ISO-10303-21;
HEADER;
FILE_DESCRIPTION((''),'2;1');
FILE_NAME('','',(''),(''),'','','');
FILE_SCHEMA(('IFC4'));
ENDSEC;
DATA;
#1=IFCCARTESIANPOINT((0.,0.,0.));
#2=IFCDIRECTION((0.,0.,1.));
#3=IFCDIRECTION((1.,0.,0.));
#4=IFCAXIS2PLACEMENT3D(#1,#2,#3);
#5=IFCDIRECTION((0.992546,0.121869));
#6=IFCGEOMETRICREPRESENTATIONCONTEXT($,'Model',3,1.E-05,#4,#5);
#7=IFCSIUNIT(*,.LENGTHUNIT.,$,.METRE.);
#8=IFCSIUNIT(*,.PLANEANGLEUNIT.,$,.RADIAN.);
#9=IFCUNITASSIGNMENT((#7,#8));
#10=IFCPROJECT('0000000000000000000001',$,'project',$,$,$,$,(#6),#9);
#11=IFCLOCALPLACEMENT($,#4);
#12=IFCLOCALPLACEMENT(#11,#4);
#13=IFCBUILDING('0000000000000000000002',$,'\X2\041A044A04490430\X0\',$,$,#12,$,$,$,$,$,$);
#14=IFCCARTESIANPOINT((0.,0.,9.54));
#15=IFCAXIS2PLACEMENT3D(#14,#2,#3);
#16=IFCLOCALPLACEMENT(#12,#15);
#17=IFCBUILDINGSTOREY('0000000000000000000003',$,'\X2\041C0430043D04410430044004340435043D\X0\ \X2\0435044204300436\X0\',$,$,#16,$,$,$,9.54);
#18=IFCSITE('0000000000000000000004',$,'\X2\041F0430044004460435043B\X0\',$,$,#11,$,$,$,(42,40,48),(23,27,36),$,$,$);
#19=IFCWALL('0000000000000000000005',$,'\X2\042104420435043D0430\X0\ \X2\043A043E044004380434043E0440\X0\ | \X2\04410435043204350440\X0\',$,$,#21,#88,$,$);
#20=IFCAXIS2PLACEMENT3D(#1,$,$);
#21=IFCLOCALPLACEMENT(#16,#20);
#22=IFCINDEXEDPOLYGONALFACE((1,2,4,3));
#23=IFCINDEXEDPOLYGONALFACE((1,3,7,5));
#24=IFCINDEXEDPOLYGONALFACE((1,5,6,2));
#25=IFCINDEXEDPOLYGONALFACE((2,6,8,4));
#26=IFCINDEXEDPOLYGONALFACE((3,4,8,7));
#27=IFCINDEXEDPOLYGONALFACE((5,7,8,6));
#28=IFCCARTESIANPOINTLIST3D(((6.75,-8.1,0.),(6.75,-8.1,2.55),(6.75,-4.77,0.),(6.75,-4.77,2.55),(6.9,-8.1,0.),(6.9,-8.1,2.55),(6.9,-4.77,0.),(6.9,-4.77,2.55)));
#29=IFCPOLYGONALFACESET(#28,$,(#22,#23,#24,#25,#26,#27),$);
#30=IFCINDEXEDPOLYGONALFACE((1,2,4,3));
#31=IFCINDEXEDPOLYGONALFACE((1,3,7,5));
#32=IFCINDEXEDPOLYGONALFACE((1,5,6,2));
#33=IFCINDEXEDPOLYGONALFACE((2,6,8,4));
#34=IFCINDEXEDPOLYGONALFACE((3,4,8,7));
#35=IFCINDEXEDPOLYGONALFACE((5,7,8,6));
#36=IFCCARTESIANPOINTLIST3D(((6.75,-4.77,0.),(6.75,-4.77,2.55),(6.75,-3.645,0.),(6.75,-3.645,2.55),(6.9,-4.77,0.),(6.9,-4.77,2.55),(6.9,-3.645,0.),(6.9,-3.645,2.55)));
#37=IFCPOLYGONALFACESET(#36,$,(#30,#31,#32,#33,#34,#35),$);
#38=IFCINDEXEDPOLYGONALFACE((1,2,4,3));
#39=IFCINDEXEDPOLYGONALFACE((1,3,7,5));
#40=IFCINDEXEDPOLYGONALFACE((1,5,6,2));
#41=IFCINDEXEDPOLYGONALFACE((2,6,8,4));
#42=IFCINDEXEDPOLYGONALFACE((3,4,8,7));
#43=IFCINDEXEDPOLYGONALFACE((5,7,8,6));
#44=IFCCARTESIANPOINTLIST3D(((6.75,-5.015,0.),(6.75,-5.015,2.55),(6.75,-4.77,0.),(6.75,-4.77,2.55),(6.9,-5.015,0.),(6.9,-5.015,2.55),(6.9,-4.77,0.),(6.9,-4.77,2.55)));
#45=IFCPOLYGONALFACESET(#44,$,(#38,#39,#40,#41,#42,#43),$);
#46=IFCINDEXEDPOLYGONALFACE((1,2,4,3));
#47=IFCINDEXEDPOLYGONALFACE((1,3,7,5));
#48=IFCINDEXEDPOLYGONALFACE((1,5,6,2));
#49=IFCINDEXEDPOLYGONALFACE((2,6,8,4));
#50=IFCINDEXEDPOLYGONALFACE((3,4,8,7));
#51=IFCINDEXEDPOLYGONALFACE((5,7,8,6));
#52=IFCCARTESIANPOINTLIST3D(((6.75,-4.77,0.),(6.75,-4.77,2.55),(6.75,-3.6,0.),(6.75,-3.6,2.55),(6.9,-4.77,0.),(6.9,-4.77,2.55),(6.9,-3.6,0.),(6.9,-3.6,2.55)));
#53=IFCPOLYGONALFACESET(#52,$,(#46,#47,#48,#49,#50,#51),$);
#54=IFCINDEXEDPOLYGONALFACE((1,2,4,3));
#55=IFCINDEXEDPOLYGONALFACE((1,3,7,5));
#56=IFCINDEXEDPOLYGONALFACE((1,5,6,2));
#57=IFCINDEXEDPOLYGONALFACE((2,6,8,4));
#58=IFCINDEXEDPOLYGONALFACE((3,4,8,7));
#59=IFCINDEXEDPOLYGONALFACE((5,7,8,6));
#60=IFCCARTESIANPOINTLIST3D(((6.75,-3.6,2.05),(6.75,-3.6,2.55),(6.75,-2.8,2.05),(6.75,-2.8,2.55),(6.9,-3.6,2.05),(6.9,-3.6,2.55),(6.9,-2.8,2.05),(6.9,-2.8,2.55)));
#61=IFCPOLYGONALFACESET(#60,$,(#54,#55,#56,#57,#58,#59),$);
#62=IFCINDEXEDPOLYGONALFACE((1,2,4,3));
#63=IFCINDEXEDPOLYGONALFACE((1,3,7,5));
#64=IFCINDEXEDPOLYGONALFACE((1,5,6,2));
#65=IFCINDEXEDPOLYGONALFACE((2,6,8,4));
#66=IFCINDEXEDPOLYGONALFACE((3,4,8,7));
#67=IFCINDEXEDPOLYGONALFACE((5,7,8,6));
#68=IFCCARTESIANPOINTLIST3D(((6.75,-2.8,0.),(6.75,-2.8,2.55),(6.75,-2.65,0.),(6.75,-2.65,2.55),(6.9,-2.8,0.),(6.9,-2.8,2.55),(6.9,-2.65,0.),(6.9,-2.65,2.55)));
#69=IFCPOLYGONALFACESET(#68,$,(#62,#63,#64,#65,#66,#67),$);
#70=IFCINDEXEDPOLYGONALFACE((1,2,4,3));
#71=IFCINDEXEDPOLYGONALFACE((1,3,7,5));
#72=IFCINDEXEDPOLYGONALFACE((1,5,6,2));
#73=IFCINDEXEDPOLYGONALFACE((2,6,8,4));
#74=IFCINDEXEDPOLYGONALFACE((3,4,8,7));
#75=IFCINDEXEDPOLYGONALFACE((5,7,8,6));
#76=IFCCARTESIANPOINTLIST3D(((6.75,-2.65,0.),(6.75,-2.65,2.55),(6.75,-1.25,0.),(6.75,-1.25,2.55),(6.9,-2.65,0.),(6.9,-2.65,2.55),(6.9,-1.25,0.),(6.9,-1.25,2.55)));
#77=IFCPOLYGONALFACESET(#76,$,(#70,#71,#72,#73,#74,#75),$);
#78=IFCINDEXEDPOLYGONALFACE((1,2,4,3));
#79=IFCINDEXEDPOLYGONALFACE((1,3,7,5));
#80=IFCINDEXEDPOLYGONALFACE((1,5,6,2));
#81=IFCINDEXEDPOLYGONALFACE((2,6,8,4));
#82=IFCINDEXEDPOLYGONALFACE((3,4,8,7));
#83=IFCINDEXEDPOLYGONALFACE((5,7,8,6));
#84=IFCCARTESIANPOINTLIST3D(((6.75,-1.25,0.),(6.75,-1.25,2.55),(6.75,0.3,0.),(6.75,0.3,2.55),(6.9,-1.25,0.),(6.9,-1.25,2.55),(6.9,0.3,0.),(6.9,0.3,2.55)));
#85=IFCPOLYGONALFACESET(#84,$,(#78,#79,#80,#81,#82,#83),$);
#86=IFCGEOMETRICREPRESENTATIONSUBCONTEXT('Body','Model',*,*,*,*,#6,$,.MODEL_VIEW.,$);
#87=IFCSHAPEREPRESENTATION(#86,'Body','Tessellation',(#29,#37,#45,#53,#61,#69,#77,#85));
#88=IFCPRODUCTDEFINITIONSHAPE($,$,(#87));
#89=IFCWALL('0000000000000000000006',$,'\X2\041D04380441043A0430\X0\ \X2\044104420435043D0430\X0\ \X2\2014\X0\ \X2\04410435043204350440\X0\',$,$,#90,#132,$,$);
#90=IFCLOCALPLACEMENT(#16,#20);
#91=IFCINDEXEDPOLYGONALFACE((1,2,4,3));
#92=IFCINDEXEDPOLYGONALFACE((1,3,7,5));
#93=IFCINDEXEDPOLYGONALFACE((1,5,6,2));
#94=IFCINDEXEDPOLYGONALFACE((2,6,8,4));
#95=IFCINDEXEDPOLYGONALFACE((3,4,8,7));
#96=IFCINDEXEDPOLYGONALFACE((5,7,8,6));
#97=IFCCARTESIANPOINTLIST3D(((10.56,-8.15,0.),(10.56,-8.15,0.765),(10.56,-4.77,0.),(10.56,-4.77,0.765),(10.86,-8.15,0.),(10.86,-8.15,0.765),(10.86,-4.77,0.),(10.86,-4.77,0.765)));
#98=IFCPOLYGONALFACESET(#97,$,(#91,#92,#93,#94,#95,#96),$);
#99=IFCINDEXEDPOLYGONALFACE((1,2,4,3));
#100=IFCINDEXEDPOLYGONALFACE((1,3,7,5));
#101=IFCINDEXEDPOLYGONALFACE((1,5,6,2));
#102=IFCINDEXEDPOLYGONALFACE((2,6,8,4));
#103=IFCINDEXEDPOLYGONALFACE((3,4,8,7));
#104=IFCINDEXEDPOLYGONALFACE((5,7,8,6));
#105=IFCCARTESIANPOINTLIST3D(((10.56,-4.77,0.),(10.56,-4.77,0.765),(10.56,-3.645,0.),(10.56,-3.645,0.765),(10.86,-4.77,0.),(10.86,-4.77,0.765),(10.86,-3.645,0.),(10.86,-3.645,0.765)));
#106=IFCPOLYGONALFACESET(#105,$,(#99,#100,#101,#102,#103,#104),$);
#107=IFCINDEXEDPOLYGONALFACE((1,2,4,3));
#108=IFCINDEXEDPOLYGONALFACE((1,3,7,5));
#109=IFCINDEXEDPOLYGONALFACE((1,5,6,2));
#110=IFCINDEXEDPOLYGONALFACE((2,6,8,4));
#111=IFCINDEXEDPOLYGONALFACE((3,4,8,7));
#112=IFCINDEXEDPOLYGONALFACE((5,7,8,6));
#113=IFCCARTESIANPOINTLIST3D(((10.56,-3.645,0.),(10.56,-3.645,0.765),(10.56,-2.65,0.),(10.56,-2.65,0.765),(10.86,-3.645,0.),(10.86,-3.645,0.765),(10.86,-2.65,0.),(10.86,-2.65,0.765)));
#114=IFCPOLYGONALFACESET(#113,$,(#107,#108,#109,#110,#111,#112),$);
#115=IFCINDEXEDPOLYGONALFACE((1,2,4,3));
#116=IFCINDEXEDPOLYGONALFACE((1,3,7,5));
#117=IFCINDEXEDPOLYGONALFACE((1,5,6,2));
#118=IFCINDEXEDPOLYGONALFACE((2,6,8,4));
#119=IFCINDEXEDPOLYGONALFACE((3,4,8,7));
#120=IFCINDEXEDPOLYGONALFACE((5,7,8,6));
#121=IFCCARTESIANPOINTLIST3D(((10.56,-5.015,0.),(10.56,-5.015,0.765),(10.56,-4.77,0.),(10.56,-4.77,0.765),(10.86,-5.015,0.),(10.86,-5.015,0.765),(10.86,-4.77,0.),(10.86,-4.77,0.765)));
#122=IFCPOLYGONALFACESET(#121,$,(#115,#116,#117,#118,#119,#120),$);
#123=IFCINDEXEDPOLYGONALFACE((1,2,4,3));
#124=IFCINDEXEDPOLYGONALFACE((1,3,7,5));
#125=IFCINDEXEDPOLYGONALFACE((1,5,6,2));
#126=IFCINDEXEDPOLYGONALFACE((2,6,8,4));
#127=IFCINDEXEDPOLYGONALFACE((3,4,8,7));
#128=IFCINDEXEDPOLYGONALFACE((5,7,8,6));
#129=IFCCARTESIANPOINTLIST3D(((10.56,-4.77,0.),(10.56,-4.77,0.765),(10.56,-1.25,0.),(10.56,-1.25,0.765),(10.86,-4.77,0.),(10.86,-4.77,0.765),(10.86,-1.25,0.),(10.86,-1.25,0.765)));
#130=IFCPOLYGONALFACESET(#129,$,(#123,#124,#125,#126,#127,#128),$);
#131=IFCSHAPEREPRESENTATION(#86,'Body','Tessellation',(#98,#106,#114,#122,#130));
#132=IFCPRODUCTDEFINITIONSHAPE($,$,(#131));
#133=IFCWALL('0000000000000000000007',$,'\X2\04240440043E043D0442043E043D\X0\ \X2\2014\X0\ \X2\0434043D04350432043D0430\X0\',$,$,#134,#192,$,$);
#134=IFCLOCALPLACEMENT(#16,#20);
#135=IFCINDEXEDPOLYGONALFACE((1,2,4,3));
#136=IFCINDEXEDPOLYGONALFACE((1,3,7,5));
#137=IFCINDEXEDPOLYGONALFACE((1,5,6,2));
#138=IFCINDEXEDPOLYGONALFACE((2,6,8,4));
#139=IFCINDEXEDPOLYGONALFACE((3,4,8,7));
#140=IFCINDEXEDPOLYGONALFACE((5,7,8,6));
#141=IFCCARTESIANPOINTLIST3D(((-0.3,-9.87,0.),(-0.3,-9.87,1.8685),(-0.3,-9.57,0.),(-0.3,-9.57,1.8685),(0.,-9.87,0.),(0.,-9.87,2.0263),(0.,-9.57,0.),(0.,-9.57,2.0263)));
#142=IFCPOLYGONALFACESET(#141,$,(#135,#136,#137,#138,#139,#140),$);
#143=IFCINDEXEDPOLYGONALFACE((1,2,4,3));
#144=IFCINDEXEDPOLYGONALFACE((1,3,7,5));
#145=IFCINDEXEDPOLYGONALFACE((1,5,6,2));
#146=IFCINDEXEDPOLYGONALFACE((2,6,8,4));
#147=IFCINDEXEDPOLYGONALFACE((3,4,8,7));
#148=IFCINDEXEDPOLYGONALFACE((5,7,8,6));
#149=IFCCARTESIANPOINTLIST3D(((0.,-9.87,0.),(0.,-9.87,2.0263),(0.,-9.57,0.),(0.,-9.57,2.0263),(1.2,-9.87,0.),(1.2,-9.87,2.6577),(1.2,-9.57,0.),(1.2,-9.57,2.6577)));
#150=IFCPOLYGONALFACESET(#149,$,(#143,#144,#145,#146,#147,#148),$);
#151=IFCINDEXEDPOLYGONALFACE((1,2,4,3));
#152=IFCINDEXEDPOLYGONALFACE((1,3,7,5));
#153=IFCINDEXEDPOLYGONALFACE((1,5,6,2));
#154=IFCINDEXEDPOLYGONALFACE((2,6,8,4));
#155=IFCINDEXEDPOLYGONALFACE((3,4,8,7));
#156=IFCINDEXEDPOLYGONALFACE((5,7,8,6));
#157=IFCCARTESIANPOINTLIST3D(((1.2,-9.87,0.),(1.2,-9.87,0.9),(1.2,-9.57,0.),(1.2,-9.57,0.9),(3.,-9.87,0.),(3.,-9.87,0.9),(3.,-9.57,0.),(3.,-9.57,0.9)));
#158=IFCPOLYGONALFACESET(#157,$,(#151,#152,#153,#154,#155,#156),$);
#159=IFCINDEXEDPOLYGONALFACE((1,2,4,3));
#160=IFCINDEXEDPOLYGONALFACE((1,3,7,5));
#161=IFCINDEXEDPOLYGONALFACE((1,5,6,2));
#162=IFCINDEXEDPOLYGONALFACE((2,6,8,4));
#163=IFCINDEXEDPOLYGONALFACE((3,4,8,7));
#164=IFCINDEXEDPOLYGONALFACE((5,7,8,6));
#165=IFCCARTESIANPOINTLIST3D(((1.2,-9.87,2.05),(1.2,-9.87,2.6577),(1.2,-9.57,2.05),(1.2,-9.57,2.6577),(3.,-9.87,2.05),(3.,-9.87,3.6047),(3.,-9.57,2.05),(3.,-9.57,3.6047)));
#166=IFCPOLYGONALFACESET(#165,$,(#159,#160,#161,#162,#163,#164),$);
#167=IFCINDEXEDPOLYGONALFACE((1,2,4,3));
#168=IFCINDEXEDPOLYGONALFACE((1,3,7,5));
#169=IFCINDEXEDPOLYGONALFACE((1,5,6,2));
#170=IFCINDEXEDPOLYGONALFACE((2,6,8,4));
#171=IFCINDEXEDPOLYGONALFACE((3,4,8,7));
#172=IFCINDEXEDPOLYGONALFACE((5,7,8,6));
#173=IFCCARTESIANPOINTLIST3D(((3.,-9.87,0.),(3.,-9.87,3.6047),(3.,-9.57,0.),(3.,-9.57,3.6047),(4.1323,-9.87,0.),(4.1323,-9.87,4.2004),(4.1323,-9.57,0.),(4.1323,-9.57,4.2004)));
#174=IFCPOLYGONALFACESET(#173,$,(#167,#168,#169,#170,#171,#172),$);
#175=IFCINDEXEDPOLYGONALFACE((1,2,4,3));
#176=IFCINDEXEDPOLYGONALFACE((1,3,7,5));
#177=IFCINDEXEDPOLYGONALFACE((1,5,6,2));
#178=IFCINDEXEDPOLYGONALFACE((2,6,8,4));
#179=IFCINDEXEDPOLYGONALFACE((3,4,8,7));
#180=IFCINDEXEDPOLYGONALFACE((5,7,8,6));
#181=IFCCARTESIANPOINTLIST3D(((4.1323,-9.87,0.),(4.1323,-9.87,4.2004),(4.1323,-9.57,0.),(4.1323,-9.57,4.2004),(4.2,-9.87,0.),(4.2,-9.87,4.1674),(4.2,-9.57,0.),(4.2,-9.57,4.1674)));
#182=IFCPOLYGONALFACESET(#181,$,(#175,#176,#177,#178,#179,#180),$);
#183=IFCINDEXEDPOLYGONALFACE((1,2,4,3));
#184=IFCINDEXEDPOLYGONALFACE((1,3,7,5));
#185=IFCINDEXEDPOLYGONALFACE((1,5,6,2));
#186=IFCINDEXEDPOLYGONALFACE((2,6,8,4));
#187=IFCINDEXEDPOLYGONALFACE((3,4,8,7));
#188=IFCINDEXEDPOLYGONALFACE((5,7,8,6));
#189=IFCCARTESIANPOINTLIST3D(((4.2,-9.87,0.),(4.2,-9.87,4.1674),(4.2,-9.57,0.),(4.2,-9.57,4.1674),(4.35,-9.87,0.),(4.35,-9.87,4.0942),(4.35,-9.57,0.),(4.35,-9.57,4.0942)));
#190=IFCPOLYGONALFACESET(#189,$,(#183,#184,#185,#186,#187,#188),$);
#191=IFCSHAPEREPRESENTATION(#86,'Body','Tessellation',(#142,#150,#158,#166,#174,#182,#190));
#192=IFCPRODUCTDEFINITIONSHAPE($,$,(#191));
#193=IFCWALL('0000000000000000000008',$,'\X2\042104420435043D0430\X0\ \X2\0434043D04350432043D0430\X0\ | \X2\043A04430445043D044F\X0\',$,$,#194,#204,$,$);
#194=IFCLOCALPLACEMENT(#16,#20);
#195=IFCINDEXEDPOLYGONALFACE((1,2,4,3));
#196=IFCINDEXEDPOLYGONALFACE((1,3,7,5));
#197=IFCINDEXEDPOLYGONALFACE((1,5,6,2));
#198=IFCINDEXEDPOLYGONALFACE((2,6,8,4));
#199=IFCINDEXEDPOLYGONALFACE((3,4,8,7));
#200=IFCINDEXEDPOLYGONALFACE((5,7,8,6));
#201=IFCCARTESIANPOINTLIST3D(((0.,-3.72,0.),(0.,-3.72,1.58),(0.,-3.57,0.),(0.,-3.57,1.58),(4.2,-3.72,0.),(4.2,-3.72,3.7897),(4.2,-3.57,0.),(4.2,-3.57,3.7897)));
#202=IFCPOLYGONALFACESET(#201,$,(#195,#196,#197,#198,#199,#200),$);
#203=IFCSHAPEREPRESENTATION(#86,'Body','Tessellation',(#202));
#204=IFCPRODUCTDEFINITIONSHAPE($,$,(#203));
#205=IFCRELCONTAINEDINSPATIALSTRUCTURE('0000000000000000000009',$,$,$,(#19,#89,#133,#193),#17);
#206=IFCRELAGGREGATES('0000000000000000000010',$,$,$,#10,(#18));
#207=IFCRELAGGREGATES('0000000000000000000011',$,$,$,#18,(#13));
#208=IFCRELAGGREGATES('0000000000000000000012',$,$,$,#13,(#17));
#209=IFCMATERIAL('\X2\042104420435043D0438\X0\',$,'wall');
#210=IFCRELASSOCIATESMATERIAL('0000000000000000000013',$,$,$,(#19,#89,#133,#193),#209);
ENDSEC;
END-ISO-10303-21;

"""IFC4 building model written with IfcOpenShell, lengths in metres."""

from ifc_helpers import new_model, si_unit, direction, frame, origin_with_axes, place, context, subcontext, project, spatial, polyline, outline, extrude, material, element, save


model = new_model("IFC4")

# Units and contexts
model_context = context("Model", 3, precision=1e-05, world=origin_with_axes(), true_north=direction((0.992546, 0.121869)))
body_context = subcontext(model_context, "Body", "Model", "MODEL_VIEW")
ifc_project = project(units=[si_unit("LENGTHUNIT", "METRE"), si_unit("PLANEANGLEUNIT", "RADIAN")], contexts=[model_context])

# Site, building, storey
site_placement = place(None, origin_with_axes())
site = spatial("IfcSite", under=ifc_project, at=site_placement, Name="Парцел", RefLatitude=(42, 40, 48), RefLongitude=(23, 27, 36))
building_placement = place(site_placement, origin_with_axes())
building = spatial("IfcBuilding", under=site, at=building_placement, Name="Къща")
storey_placement = place(building_placement, frame((0.0, 0.0, 9.54), z_axis=(0.0, 0.0, 1.0), x_axis=(1.0, 0.0, 0.0)))
storey = spatial("IfcBuildingStorey", under=building, at=storey_placement, Name="Мансарден етаж", Elevation=9.54)

# Walls
ifc_material_1 = material(Name="Стени", Category="wall")
wall_1_placement = place(storey_placement, origin_with_axes())
element("IfcWall", 1, at=wall_1_placement, inside=storey, material=ifc_material_1, Name="Стена коридор | север", context=body_context, shape_type="SweptSolid", body=[
    extrude(outline(polyline([(6.75, 0.0), (6.9, 0.0), (6.9, -2.55), (6.75, -2.55), (6.75, 0.0)])), frame((0.0, -8.1, 0.0), z_axis=(0.0, 1.0, 0.0), x_axis=(1.0, 0.0, 0.0)), (0.0, 0.0, 1.0), 3.33),
    extrude(outline(polyline([(6.75, 0.0), (6.9, 0.0), (6.9, -2.55), (6.75, -2.55), (6.75, 0.0)])), frame((0.0, -4.77, 0.0), z_axis=(0.0, 1.0, 0.0), x_axis=(1.0, 0.0, 0.0)), (0.0, 0.0, 1.0), 1.125),
    extrude(outline(polyline([(6.75, 0.0), (6.9, 0.0), (6.9, -2.55), (6.75, -2.55), (6.75, 0.0)])), frame((0.0, -5.015, 0.0), z_axis=(0.0, 1.0, 0.0), x_axis=(1.0, 0.0, 0.0)), (0.0, 0.0, 1.0), 0.245),
    extrude(outline(polyline([(6.75, 0.0), (6.9, 0.0), (6.9, -2.55), (6.75, -2.55), (6.75, 0.0)])), frame((0.0, -4.77, 0.0), z_axis=(0.0, 1.0, 0.0), x_axis=(1.0, 0.0, 0.0)), (0.0, 0.0, 1.0), 1.17),
    extrude(outline(polyline([(6.75, -2.05), (6.9, -2.05), (6.9, -2.55), (6.75, -2.55), (6.75, -2.05)])), frame((0.0, -3.6, 0.0), z_axis=(0.0, 1.0, 0.0), x_axis=(1.0, 0.0, 0.0)), (0.0, 0.0, 1.0), 0.8),
    extrude(outline(polyline([(6.75, 0.0), (6.9, 0.0), (6.9, -2.55), (6.75, -2.55), (6.75, 0.0)])), frame((0.0, -2.8, 0.0), z_axis=(0.0, 1.0, 0.0), x_axis=(1.0, 0.0, 0.0)), (0.0, 0.0, 1.0), 0.15),
    extrude(outline(polyline([(6.75, 0.0), (6.9, 0.0), (6.9, -2.55), (6.75, -2.55), (6.75, 0.0)])), frame((0.0, -2.65, 0.0), z_axis=(0.0, 1.0, 0.0), x_axis=(1.0, 0.0, 0.0)), (0.0, 0.0, 1.0), 1.4),
    extrude(outline(polyline([(6.75, 0.0), (6.9, 0.0), (6.9, -2.55), (6.75, -2.55), (6.75, 0.0)])), frame((0.0, -1.25, 0.0), z_axis=(0.0, 1.0, 0.0), x_axis=(1.0, 0.0, 0.0)), (0.0, 0.0, 1.0), 1.55),
])
wall_2_placement = place(storey_placement, origin_with_axes())
element("IfcWall", 2, at=wall_2_placement, inside=storey, material=ifc_material_1, Name="Ниска стена — север", context=body_context, shape_type="SweptSolid", body=[
    extrude(outline(polyline([(10.56, 0.0), (10.86, 0.0), (10.86, -0.765), (10.56, -0.765), (10.56, 0.0)])), frame((0.0, -8.15, 0.0), z_axis=(0.0, 1.0, 0.0), x_axis=(1.0, 0.0, 0.0)), (0.0, 0.0, 1.0), 3.38),
    extrude(outline(polyline([(10.56, 0.0), (10.86, 0.0), (10.86, -0.765), (10.56, -0.765), (10.56, 0.0)])), frame((0.0, -4.77, 0.0), z_axis=(0.0, 1.0, 0.0), x_axis=(1.0, 0.0, 0.0)), (0.0, 0.0, 1.0), 1.125),
    extrude(outline(polyline([(10.56, 0.0), (10.86, 0.0), (10.86, -0.765), (10.56, -0.765), (10.56, 0.0)])), frame((0.0, -3.645, 0.0), z_axis=(0.0, 1.0, 0.0), x_axis=(1.0, 0.0, 0.0)), (0.0, 0.0, 1.0), 0.995),
    extrude(outline(polyline([(10.56, 0.0), (10.86, 0.0), (10.86, -0.765), (10.56, -0.765), (10.56, 0.0)])), frame((0.0, -5.015, 0.0), z_axis=(0.0, 1.0, 0.0), x_axis=(1.0, 0.0, 0.0)), (0.0, 0.0, 1.0), 0.245),
    extrude(outline(polyline([(10.56, 0.0), (10.86, 0.0), (10.86, -0.765), (10.56, -0.765), (10.56, 0.0)])), frame((0.0, -4.77, 0.0), z_axis=(0.0, 1.0, 0.0), x_axis=(1.0, 0.0, 0.0)), (0.0, 0.0, 1.0), 3.52),
])
wall_3_placement = place(storey_placement, origin_with_axes())
element("IfcWall", 3, at=wall_3_placement, inside=storey, material=ifc_material_1, Name="Фронтон — дневна", context=body_context, shape_type="SweptSolid", body=[
    extrude(outline(polyline([(-0.3, 0.0), (0.0, 0.0), (0.0, -2.0263), (-0.3, -1.8685), (-0.3, 0.0)])), frame((0.0, -9.87, 0.0), z_axis=(0.0, 1.0, 0.0), x_axis=(1.0, 0.0, 0.0)), (0.0, 0.0, 1.0), 0.3),
    extrude(outline(polyline([(0.0, 0.0), (1.2, 0.0), (1.2, -2.6577), (0.0, -2.0263), (0.0, 0.0)])), frame((0.0, -9.87, 0.0), z_axis=(0.0, 1.0, 0.0), x_axis=(1.0, 0.0, 0.0)), (0.0, 0.0, 1.0), 0.3),
    extrude(outline(polyline([(1.2, 0.0), (3.0, 0.0), (3.0, -0.9), (1.2, -0.9), (1.2, 0.0)])), frame((0.0, -9.87, 0.0), z_axis=(0.0, 1.0, 0.0), x_axis=(1.0, 0.0, 0.0)), (0.0, 0.0, 1.0), 0.3),
    extrude(outline(polyline([(1.2, -2.05), (3.0, -2.05), (3.0, -3.6047), (1.2, -2.6577), (1.2, -2.05)])), frame((0.0, -9.87, 0.0), z_axis=(0.0, 1.0, 0.0), x_axis=(1.0, 0.0, 0.0)), (0.0, 0.0, 1.0), 0.3),
    extrude(outline(polyline([(3.0, 0.0), (4.1323, 0.0), (4.1323, -4.2004), (3.0, -3.6047), (3.0, 0.0)])), frame((0.0, -9.87, 0.0), z_axis=(0.0, 1.0, 0.0), x_axis=(1.0, 0.0, 0.0)), (0.0, 0.0, 1.0), 0.3),
    extrude(outline(polyline([(4.1323, 0.0), (4.2, 0.0), (4.2, -4.1674), (4.1323, -4.2004), (4.1323, 0.0)])), frame((0.0, -9.87, 0.0), z_axis=(0.0, 1.0, 0.0), x_axis=(1.0, 0.0, 0.0)), (0.0, 0.0, 1.0), 0.3),
    extrude(outline(polyline([(4.2, 0.0), (4.35, 0.0), (4.35, -4.0942), (4.2, -4.1674), (4.2, 0.0)])), frame((0.0, -9.87, 0.0), z_axis=(0.0, 1.0, 0.0), x_axis=(1.0, 0.0, 0.0)), (0.0, 0.0, 1.0), 0.3),
])
wall_4_placement = place(storey_placement, origin_with_axes())
element("IfcWall", 4, at=wall_4_placement, inside=storey, material=ifc_material_1, Name="Стена дневна | кухня", context=body_context, shape_type="SweptSolid", body=[
    extrude(outline(polyline([(0.0, 0.0), (4.2, 0.0), (4.2, -3.7897), (0.0, -1.58), (0.0, 0.0)])), frame((0.0, -3.72, 0.0), z_axis=(0.0, 1.0, 0.0), x_axis=(1.0, 0.0, 0.0)), (0.0, 0.0, 1.0), 0.15),
])

save(model, "model.ifc")
